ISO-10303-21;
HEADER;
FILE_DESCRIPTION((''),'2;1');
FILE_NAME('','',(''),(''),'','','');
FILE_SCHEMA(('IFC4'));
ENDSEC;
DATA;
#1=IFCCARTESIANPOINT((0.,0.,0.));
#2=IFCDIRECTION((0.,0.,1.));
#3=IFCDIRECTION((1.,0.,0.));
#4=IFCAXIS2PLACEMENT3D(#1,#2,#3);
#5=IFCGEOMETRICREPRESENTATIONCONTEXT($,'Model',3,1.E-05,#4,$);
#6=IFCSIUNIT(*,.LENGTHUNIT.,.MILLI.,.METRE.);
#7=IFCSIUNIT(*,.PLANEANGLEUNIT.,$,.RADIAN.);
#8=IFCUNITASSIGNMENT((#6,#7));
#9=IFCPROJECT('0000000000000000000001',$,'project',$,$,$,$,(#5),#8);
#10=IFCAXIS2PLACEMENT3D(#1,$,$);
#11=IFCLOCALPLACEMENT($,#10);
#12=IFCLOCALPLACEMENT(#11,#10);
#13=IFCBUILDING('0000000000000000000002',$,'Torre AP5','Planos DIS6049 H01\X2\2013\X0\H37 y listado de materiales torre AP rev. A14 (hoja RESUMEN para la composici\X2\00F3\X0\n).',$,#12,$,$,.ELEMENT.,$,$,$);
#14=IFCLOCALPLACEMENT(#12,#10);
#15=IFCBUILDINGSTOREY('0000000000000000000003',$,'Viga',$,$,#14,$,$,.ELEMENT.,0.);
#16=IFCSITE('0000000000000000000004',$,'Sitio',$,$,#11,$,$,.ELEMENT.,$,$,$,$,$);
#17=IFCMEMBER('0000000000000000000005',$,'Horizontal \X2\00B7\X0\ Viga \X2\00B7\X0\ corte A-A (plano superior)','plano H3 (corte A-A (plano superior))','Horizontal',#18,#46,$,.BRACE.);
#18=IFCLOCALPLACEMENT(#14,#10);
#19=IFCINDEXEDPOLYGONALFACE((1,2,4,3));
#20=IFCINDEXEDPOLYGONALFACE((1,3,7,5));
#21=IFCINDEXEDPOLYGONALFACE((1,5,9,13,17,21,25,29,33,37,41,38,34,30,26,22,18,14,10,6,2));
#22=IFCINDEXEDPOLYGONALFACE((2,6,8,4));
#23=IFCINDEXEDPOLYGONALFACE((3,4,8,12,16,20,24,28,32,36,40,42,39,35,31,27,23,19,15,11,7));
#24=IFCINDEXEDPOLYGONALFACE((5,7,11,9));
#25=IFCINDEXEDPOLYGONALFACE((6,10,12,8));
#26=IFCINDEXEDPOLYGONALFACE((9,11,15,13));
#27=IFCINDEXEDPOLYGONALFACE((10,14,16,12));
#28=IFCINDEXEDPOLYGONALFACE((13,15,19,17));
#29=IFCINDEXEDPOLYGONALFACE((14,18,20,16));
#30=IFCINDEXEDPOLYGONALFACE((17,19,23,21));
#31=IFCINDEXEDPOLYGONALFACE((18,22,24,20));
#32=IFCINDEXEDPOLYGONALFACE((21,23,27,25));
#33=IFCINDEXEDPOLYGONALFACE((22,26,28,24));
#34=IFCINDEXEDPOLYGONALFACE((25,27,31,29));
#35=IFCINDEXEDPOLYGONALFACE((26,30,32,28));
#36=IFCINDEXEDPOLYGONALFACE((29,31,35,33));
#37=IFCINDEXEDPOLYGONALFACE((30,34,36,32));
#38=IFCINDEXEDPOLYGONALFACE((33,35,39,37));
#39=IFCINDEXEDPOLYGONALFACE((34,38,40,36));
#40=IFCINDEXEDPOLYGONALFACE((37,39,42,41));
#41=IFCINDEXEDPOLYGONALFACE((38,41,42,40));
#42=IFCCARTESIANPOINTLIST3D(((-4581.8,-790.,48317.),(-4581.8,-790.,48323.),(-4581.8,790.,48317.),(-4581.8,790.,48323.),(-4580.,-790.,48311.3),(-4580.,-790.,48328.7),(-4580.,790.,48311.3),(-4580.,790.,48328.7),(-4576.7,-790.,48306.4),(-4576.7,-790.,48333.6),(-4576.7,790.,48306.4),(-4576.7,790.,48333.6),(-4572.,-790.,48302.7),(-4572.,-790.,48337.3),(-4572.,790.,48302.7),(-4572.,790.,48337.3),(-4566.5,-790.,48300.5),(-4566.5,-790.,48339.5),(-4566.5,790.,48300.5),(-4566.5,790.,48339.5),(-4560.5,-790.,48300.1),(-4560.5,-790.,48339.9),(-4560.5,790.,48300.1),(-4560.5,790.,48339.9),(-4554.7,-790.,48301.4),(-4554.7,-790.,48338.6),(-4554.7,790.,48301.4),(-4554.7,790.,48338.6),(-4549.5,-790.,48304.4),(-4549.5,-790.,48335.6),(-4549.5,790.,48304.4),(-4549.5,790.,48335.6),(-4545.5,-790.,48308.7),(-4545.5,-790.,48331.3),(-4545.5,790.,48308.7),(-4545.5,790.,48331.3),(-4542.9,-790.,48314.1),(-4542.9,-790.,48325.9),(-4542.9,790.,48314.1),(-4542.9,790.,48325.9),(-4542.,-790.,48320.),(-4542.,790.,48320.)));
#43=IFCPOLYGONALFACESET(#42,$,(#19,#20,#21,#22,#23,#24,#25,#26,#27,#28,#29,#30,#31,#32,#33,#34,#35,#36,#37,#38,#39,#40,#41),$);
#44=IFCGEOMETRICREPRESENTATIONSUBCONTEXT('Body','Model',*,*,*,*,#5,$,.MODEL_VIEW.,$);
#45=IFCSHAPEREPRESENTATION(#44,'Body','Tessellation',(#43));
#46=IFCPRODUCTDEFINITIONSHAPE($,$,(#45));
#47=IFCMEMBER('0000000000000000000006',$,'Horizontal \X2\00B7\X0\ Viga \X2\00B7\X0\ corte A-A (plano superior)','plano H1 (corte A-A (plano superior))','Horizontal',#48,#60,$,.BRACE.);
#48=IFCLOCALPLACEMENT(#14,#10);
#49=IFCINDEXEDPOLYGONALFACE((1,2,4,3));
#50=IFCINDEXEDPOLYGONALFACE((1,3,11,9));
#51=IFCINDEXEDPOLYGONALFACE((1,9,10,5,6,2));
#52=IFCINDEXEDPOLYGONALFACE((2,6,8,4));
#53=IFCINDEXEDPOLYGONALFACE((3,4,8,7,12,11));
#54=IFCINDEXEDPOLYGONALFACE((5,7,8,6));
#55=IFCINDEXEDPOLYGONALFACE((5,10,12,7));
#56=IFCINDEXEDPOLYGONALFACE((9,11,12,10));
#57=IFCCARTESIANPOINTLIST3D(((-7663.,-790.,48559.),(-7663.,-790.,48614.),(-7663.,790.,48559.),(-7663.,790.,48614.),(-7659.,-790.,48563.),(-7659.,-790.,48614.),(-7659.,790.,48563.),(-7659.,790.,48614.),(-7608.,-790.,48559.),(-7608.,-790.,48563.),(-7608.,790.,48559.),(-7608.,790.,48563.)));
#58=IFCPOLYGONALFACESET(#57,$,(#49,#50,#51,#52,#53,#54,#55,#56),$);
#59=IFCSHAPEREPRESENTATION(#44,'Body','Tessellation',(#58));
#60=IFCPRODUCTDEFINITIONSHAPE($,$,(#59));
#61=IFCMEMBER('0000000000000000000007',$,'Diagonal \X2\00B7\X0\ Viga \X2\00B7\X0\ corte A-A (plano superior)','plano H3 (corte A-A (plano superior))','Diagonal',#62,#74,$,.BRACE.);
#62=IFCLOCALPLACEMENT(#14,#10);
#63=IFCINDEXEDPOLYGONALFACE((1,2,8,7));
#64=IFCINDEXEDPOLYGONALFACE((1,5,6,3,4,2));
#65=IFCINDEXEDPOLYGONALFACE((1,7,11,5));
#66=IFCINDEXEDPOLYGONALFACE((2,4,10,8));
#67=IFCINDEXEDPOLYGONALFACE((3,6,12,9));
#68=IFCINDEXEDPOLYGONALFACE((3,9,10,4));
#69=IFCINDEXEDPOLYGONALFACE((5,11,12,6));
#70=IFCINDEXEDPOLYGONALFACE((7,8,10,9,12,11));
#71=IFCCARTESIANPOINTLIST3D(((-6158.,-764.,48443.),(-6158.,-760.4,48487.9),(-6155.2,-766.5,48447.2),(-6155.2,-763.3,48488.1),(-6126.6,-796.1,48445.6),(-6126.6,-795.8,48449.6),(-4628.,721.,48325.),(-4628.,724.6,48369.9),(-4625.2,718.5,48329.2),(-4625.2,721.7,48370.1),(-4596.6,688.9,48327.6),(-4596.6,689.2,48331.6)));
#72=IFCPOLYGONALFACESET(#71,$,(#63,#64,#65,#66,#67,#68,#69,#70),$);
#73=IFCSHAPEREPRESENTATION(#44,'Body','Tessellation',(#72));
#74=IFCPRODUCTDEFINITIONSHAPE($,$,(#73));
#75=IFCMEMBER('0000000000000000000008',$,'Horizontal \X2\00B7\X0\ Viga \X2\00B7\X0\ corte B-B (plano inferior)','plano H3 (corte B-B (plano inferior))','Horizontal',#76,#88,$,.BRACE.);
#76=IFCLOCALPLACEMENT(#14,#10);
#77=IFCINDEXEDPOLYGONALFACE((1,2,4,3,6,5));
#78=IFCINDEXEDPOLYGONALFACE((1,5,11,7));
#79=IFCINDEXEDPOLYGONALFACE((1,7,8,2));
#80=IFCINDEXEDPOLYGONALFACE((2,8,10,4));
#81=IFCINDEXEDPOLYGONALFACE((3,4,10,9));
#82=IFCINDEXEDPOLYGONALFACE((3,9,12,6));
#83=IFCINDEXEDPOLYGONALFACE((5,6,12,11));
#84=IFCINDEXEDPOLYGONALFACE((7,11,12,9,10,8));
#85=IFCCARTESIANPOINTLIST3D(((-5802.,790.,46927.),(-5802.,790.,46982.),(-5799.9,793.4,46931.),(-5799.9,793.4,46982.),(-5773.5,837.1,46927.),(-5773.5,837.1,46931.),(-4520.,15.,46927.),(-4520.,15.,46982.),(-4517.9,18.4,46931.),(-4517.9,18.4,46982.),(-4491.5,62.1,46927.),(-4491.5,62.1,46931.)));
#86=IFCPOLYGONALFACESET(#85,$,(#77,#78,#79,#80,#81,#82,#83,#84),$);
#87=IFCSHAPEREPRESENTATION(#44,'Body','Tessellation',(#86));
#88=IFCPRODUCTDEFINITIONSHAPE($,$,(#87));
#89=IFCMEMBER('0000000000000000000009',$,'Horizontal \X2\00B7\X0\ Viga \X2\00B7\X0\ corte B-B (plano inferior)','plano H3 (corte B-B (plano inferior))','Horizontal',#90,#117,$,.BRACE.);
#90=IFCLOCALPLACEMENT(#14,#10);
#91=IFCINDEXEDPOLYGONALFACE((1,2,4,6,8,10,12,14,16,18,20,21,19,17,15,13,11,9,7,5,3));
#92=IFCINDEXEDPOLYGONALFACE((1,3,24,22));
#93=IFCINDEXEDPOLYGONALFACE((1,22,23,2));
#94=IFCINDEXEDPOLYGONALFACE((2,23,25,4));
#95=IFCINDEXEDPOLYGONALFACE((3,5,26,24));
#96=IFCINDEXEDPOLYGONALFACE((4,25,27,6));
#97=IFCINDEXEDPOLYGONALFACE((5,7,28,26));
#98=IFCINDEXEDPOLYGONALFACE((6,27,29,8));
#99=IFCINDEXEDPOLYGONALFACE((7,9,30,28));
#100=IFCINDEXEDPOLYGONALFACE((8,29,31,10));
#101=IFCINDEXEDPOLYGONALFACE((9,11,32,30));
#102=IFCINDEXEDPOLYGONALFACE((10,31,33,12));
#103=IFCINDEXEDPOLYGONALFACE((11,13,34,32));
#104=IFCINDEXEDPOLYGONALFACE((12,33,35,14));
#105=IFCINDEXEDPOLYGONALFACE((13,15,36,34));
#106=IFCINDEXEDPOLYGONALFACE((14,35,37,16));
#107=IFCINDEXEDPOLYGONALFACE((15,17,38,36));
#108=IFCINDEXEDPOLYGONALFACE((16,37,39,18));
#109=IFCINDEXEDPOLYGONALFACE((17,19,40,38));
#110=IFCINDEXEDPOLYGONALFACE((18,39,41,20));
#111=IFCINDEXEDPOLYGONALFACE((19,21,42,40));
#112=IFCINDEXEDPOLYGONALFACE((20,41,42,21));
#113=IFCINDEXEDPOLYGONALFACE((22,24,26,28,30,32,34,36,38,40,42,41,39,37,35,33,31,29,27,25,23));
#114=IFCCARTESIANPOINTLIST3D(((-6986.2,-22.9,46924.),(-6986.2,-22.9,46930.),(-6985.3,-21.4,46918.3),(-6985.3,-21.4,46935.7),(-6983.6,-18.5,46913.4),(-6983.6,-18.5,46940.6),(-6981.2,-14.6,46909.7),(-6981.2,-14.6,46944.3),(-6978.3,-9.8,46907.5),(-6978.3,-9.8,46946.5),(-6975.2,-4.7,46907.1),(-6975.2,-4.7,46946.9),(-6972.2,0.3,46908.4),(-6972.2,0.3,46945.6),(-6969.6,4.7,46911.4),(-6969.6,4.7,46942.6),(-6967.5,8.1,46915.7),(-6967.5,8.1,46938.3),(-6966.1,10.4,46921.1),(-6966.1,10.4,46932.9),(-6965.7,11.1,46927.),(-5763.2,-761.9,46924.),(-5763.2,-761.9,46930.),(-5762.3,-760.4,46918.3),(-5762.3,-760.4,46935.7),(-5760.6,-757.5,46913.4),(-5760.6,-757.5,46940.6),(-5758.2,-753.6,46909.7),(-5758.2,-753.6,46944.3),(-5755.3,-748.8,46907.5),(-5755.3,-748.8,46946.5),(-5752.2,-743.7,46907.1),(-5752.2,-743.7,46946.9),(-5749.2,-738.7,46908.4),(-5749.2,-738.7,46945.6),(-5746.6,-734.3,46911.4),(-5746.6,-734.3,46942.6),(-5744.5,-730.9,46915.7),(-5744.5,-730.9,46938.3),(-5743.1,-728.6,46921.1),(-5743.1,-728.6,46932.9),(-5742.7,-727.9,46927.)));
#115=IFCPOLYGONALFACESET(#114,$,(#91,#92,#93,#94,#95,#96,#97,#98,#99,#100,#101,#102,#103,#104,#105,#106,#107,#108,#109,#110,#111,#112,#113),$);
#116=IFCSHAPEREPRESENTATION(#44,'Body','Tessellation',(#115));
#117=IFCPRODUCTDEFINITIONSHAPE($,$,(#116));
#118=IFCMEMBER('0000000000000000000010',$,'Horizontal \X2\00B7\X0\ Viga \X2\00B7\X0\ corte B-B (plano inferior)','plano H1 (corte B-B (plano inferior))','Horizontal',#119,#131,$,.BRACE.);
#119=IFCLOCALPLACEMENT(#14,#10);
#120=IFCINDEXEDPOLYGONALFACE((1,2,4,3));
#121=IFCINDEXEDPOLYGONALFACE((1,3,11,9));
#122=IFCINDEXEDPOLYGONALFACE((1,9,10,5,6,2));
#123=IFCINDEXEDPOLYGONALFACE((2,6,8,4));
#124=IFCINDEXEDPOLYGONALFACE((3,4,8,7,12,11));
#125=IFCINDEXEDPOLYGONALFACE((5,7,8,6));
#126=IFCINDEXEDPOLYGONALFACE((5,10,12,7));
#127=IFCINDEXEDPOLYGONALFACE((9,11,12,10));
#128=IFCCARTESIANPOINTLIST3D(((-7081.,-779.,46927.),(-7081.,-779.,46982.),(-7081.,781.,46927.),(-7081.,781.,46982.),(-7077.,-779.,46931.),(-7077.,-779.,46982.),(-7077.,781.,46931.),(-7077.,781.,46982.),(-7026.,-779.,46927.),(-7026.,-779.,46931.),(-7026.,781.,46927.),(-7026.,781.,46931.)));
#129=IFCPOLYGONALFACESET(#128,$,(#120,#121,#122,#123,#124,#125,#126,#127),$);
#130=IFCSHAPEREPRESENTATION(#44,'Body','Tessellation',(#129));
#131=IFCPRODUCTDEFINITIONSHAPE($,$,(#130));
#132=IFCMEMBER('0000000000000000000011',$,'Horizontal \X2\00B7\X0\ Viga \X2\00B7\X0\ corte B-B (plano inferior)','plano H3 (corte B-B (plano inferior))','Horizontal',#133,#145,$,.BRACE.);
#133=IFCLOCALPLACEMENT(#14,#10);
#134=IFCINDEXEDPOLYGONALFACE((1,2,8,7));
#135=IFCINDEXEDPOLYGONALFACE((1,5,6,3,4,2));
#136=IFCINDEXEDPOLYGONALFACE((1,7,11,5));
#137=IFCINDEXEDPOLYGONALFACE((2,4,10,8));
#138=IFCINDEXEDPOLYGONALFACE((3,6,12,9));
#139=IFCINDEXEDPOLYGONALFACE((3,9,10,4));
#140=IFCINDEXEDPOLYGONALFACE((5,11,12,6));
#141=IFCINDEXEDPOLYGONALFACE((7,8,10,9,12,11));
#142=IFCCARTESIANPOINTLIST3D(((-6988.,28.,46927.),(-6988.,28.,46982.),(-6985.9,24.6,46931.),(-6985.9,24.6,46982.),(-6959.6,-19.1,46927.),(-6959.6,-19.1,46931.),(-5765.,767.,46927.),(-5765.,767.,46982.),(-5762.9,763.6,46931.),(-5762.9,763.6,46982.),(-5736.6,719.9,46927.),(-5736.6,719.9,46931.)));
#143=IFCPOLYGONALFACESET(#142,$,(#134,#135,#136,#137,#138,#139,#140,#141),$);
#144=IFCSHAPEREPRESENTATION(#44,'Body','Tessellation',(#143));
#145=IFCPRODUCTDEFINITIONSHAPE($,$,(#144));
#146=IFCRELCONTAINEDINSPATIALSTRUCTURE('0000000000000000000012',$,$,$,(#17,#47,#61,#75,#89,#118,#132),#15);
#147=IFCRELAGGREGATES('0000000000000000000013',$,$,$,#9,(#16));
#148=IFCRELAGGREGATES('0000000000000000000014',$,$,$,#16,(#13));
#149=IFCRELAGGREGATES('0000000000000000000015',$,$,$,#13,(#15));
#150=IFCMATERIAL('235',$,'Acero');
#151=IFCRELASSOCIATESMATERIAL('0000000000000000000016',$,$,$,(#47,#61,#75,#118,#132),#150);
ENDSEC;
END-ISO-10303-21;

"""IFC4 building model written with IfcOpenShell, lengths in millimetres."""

from ifc_helpers import new_model, si_unit, frame, frame_2d, origin, origin_with_axes, place, context, subcontext, project, spatial, circle, l_section, extrude, material, element, save


model = new_model("IFC4")

# Units and contexts
model_context = context("Model", 3, precision=1e-05, world=origin_with_axes())
body_context = subcontext(model_context, "Body", "Model", "MODEL_VIEW")
ifc_project = project(units=[si_unit("LENGTHUNIT", "METRE", prefix="MILLI"), si_unit("PLANEANGLEUNIT", "RADIAN")], contexts=[model_context])

# Site, building, storey
site_placement = place(None, origin())
site = spatial("IfcSite", under=ifc_project, at=site_placement, Name="Sitio", CompositionType="ELEMENT")
building_placement = place(site_placement, origin())
building = spatial("IfcBuilding", under=site, at=building_placement, Name="Torre AP5", Description="Planos DIS6049 H01–H37 y listado de materiales torre AP rev. A14 (hoja RESUMEN para la composición).", CompositionType="ELEMENT")
storey_placement = place(building_placement, origin())
storey = spatial("IfcBuildingStorey", under=building, at=storey_placement, Name="Viga", CompositionType="ELEMENT", Elevation=0.0)

# Members
ifc_material_1 = material(Name="235", Category="Acero")
member_1_placement = place(storey_placement, frame((-4562.0, 790.0, 48320.0), z_axis=(0.0, -1.0, 0.0), x_axis=(1.0, 0.0, 0.0)))
element("IfcMember", 1, at=member_1_placement, inside=storey, Name="Horizontal · Viga · corte A-A (plano superior)", Description="plano H3 (corte A-A (plano superior))", ObjectType="Horizontal", PredefinedType="BRACE", context=body_context, shape_type="SweptSolid", body=[
    extrude(circle(Radius=20.0), None, (0.0, 0.0, 1.0), 1580.0),
])
member_2_placement = place(storey_placement, frame((-7663.0, 790.0, 48559.0), z_axis=(0.0, -1.0, 0.0), x_axis=(1.0, 0.0, 0.0)))
element("IfcMember", 2, at=member_2_placement, inside=storey, material=ifc_material_1, Name="Horizontal · Viga · corte A-A (plano superior)", Description="plano H1 (corte A-A (plano superior))", ObjectType="Horizontal", PredefinedType="BRACE", context=body_context, shape_type="SweptSolid", body=[
    extrude(l_section(Depth=55.0, Width=55.0, Thickness=4.0, at=frame_2d((27.5, 27.5))), None, (0.0, 0.0, 1.0), 1580.0),
])
member_3_placement = place(storey_placement, frame((-4628.0, 721.0, 48325.0), z_axis=(-0.716484, -0.695411, 0.055258), x_axis=(0.697603, -0.714197, 0.057207)))
element("IfcMember", 3, at=member_3_placement, inside=storey, material=ifc_material_1, Name="Diagonal · Viga · corte A-A (plano superior)", Description="plano H3 (corte A-A (plano superior))", ObjectType="Diagonal", PredefinedType="BRACE", context=body_context, shape_type="SweptSolid", body=[
    extrude(l_section(Depth=45.0, Width=45.0, Thickness=4.0, at=frame_2d((22.5, 22.5))), None, (0.0, 0.0, 1.0), 2135.4),
])
member_4_placement = place(storey_placement, frame((-5802.0, 790.0, 46927.0), z_axis=(0.85578, -0.51734, 0.0), x_axis=(0.51734, 0.85578, 0.0)))
element("IfcMember", 4, at=member_4_placement, inside=storey, material=ifc_material_1, Name="Horizontal · Viga · corte B-B (plano inferior)", Description="plano H3 (corte B-B (plano inferior))", ObjectType="Horizontal", PredefinedType="BRACE", context=body_context, shape_type="SweptSolid", body=[
    extrude(l_section(Depth=55.0, Width=55.0, Thickness=4.0, at=frame_2d((27.5, 27.5))), None, (0.0, 0.0, 1.0), 1498.0),
])
member_5_placement = place(storey_placement, frame((-6976.0, -6.0, 46927.0), z_axis=(0.855883, -0.517169, 0.0), x_axis=(0.517169, 0.855883, 0.0)))
element("IfcMember", 5, at=member_5_placement, inside=storey, Name="Horizontal · Viga · corte B-B (plano inferior)", Description="plano H3 (corte B-B (plano inferior))", ObjectType="Horizontal", PredefinedType="BRACE", context=body_context, shape_type="SweptSolid", body=[
    extrude(circle(Radius=20.0), None, (0.0, 0.0, 1.0), 1428.9),
])
member_6_placement = place(storey_placement, frame((-7081.0, 781.0, 46927.0), z_axis=(0.0, -1.0, 0.0), x_axis=(1.0, 0.0, 0.0)))
element("IfcMember", 6, at=member_6_placement, inside=storey, material=ifc_material_1, Name="Horizontal · Viga · corte B-B (plano inferior)", Description="plano H1 (corte B-B (plano inferior))", ObjectType="Horizontal", PredefinedType="BRACE", context=body_context, shape_type="SweptSolid", body=[
    extrude(l_section(Depth=55.0, Width=55.0, Thickness=4.0, at=frame_2d((27.5, 27.5))), None, (0.0, 0.0, 1.0), 1560.0),
])
member_7_placement = place(storey_placement, frame((-5765.0, 767.0, 46927.0), z_axis=(-0.855883, -0.517169, 0.0), x_axis=(0.517169, -0.855883, 0.0)))
element("IfcMember", 7, at=member_7_placement, inside=storey, material=ifc_material_1, Name="Horizontal · Viga · corte B-B (plano inferior)", Description="plano H3 (corte B-B (plano inferior))", ObjectType="Horizontal", PredefinedType="BRACE", context=body_context, shape_type="SweptSolid", body=[
    extrude(l_section(Depth=55.0, Width=55.0, Thickness=4.0, at=frame_2d((27.5, 27.5))), None, (0.0, 0.0, 1.0), 1428.9),
])

save(model, "model.ifc")
